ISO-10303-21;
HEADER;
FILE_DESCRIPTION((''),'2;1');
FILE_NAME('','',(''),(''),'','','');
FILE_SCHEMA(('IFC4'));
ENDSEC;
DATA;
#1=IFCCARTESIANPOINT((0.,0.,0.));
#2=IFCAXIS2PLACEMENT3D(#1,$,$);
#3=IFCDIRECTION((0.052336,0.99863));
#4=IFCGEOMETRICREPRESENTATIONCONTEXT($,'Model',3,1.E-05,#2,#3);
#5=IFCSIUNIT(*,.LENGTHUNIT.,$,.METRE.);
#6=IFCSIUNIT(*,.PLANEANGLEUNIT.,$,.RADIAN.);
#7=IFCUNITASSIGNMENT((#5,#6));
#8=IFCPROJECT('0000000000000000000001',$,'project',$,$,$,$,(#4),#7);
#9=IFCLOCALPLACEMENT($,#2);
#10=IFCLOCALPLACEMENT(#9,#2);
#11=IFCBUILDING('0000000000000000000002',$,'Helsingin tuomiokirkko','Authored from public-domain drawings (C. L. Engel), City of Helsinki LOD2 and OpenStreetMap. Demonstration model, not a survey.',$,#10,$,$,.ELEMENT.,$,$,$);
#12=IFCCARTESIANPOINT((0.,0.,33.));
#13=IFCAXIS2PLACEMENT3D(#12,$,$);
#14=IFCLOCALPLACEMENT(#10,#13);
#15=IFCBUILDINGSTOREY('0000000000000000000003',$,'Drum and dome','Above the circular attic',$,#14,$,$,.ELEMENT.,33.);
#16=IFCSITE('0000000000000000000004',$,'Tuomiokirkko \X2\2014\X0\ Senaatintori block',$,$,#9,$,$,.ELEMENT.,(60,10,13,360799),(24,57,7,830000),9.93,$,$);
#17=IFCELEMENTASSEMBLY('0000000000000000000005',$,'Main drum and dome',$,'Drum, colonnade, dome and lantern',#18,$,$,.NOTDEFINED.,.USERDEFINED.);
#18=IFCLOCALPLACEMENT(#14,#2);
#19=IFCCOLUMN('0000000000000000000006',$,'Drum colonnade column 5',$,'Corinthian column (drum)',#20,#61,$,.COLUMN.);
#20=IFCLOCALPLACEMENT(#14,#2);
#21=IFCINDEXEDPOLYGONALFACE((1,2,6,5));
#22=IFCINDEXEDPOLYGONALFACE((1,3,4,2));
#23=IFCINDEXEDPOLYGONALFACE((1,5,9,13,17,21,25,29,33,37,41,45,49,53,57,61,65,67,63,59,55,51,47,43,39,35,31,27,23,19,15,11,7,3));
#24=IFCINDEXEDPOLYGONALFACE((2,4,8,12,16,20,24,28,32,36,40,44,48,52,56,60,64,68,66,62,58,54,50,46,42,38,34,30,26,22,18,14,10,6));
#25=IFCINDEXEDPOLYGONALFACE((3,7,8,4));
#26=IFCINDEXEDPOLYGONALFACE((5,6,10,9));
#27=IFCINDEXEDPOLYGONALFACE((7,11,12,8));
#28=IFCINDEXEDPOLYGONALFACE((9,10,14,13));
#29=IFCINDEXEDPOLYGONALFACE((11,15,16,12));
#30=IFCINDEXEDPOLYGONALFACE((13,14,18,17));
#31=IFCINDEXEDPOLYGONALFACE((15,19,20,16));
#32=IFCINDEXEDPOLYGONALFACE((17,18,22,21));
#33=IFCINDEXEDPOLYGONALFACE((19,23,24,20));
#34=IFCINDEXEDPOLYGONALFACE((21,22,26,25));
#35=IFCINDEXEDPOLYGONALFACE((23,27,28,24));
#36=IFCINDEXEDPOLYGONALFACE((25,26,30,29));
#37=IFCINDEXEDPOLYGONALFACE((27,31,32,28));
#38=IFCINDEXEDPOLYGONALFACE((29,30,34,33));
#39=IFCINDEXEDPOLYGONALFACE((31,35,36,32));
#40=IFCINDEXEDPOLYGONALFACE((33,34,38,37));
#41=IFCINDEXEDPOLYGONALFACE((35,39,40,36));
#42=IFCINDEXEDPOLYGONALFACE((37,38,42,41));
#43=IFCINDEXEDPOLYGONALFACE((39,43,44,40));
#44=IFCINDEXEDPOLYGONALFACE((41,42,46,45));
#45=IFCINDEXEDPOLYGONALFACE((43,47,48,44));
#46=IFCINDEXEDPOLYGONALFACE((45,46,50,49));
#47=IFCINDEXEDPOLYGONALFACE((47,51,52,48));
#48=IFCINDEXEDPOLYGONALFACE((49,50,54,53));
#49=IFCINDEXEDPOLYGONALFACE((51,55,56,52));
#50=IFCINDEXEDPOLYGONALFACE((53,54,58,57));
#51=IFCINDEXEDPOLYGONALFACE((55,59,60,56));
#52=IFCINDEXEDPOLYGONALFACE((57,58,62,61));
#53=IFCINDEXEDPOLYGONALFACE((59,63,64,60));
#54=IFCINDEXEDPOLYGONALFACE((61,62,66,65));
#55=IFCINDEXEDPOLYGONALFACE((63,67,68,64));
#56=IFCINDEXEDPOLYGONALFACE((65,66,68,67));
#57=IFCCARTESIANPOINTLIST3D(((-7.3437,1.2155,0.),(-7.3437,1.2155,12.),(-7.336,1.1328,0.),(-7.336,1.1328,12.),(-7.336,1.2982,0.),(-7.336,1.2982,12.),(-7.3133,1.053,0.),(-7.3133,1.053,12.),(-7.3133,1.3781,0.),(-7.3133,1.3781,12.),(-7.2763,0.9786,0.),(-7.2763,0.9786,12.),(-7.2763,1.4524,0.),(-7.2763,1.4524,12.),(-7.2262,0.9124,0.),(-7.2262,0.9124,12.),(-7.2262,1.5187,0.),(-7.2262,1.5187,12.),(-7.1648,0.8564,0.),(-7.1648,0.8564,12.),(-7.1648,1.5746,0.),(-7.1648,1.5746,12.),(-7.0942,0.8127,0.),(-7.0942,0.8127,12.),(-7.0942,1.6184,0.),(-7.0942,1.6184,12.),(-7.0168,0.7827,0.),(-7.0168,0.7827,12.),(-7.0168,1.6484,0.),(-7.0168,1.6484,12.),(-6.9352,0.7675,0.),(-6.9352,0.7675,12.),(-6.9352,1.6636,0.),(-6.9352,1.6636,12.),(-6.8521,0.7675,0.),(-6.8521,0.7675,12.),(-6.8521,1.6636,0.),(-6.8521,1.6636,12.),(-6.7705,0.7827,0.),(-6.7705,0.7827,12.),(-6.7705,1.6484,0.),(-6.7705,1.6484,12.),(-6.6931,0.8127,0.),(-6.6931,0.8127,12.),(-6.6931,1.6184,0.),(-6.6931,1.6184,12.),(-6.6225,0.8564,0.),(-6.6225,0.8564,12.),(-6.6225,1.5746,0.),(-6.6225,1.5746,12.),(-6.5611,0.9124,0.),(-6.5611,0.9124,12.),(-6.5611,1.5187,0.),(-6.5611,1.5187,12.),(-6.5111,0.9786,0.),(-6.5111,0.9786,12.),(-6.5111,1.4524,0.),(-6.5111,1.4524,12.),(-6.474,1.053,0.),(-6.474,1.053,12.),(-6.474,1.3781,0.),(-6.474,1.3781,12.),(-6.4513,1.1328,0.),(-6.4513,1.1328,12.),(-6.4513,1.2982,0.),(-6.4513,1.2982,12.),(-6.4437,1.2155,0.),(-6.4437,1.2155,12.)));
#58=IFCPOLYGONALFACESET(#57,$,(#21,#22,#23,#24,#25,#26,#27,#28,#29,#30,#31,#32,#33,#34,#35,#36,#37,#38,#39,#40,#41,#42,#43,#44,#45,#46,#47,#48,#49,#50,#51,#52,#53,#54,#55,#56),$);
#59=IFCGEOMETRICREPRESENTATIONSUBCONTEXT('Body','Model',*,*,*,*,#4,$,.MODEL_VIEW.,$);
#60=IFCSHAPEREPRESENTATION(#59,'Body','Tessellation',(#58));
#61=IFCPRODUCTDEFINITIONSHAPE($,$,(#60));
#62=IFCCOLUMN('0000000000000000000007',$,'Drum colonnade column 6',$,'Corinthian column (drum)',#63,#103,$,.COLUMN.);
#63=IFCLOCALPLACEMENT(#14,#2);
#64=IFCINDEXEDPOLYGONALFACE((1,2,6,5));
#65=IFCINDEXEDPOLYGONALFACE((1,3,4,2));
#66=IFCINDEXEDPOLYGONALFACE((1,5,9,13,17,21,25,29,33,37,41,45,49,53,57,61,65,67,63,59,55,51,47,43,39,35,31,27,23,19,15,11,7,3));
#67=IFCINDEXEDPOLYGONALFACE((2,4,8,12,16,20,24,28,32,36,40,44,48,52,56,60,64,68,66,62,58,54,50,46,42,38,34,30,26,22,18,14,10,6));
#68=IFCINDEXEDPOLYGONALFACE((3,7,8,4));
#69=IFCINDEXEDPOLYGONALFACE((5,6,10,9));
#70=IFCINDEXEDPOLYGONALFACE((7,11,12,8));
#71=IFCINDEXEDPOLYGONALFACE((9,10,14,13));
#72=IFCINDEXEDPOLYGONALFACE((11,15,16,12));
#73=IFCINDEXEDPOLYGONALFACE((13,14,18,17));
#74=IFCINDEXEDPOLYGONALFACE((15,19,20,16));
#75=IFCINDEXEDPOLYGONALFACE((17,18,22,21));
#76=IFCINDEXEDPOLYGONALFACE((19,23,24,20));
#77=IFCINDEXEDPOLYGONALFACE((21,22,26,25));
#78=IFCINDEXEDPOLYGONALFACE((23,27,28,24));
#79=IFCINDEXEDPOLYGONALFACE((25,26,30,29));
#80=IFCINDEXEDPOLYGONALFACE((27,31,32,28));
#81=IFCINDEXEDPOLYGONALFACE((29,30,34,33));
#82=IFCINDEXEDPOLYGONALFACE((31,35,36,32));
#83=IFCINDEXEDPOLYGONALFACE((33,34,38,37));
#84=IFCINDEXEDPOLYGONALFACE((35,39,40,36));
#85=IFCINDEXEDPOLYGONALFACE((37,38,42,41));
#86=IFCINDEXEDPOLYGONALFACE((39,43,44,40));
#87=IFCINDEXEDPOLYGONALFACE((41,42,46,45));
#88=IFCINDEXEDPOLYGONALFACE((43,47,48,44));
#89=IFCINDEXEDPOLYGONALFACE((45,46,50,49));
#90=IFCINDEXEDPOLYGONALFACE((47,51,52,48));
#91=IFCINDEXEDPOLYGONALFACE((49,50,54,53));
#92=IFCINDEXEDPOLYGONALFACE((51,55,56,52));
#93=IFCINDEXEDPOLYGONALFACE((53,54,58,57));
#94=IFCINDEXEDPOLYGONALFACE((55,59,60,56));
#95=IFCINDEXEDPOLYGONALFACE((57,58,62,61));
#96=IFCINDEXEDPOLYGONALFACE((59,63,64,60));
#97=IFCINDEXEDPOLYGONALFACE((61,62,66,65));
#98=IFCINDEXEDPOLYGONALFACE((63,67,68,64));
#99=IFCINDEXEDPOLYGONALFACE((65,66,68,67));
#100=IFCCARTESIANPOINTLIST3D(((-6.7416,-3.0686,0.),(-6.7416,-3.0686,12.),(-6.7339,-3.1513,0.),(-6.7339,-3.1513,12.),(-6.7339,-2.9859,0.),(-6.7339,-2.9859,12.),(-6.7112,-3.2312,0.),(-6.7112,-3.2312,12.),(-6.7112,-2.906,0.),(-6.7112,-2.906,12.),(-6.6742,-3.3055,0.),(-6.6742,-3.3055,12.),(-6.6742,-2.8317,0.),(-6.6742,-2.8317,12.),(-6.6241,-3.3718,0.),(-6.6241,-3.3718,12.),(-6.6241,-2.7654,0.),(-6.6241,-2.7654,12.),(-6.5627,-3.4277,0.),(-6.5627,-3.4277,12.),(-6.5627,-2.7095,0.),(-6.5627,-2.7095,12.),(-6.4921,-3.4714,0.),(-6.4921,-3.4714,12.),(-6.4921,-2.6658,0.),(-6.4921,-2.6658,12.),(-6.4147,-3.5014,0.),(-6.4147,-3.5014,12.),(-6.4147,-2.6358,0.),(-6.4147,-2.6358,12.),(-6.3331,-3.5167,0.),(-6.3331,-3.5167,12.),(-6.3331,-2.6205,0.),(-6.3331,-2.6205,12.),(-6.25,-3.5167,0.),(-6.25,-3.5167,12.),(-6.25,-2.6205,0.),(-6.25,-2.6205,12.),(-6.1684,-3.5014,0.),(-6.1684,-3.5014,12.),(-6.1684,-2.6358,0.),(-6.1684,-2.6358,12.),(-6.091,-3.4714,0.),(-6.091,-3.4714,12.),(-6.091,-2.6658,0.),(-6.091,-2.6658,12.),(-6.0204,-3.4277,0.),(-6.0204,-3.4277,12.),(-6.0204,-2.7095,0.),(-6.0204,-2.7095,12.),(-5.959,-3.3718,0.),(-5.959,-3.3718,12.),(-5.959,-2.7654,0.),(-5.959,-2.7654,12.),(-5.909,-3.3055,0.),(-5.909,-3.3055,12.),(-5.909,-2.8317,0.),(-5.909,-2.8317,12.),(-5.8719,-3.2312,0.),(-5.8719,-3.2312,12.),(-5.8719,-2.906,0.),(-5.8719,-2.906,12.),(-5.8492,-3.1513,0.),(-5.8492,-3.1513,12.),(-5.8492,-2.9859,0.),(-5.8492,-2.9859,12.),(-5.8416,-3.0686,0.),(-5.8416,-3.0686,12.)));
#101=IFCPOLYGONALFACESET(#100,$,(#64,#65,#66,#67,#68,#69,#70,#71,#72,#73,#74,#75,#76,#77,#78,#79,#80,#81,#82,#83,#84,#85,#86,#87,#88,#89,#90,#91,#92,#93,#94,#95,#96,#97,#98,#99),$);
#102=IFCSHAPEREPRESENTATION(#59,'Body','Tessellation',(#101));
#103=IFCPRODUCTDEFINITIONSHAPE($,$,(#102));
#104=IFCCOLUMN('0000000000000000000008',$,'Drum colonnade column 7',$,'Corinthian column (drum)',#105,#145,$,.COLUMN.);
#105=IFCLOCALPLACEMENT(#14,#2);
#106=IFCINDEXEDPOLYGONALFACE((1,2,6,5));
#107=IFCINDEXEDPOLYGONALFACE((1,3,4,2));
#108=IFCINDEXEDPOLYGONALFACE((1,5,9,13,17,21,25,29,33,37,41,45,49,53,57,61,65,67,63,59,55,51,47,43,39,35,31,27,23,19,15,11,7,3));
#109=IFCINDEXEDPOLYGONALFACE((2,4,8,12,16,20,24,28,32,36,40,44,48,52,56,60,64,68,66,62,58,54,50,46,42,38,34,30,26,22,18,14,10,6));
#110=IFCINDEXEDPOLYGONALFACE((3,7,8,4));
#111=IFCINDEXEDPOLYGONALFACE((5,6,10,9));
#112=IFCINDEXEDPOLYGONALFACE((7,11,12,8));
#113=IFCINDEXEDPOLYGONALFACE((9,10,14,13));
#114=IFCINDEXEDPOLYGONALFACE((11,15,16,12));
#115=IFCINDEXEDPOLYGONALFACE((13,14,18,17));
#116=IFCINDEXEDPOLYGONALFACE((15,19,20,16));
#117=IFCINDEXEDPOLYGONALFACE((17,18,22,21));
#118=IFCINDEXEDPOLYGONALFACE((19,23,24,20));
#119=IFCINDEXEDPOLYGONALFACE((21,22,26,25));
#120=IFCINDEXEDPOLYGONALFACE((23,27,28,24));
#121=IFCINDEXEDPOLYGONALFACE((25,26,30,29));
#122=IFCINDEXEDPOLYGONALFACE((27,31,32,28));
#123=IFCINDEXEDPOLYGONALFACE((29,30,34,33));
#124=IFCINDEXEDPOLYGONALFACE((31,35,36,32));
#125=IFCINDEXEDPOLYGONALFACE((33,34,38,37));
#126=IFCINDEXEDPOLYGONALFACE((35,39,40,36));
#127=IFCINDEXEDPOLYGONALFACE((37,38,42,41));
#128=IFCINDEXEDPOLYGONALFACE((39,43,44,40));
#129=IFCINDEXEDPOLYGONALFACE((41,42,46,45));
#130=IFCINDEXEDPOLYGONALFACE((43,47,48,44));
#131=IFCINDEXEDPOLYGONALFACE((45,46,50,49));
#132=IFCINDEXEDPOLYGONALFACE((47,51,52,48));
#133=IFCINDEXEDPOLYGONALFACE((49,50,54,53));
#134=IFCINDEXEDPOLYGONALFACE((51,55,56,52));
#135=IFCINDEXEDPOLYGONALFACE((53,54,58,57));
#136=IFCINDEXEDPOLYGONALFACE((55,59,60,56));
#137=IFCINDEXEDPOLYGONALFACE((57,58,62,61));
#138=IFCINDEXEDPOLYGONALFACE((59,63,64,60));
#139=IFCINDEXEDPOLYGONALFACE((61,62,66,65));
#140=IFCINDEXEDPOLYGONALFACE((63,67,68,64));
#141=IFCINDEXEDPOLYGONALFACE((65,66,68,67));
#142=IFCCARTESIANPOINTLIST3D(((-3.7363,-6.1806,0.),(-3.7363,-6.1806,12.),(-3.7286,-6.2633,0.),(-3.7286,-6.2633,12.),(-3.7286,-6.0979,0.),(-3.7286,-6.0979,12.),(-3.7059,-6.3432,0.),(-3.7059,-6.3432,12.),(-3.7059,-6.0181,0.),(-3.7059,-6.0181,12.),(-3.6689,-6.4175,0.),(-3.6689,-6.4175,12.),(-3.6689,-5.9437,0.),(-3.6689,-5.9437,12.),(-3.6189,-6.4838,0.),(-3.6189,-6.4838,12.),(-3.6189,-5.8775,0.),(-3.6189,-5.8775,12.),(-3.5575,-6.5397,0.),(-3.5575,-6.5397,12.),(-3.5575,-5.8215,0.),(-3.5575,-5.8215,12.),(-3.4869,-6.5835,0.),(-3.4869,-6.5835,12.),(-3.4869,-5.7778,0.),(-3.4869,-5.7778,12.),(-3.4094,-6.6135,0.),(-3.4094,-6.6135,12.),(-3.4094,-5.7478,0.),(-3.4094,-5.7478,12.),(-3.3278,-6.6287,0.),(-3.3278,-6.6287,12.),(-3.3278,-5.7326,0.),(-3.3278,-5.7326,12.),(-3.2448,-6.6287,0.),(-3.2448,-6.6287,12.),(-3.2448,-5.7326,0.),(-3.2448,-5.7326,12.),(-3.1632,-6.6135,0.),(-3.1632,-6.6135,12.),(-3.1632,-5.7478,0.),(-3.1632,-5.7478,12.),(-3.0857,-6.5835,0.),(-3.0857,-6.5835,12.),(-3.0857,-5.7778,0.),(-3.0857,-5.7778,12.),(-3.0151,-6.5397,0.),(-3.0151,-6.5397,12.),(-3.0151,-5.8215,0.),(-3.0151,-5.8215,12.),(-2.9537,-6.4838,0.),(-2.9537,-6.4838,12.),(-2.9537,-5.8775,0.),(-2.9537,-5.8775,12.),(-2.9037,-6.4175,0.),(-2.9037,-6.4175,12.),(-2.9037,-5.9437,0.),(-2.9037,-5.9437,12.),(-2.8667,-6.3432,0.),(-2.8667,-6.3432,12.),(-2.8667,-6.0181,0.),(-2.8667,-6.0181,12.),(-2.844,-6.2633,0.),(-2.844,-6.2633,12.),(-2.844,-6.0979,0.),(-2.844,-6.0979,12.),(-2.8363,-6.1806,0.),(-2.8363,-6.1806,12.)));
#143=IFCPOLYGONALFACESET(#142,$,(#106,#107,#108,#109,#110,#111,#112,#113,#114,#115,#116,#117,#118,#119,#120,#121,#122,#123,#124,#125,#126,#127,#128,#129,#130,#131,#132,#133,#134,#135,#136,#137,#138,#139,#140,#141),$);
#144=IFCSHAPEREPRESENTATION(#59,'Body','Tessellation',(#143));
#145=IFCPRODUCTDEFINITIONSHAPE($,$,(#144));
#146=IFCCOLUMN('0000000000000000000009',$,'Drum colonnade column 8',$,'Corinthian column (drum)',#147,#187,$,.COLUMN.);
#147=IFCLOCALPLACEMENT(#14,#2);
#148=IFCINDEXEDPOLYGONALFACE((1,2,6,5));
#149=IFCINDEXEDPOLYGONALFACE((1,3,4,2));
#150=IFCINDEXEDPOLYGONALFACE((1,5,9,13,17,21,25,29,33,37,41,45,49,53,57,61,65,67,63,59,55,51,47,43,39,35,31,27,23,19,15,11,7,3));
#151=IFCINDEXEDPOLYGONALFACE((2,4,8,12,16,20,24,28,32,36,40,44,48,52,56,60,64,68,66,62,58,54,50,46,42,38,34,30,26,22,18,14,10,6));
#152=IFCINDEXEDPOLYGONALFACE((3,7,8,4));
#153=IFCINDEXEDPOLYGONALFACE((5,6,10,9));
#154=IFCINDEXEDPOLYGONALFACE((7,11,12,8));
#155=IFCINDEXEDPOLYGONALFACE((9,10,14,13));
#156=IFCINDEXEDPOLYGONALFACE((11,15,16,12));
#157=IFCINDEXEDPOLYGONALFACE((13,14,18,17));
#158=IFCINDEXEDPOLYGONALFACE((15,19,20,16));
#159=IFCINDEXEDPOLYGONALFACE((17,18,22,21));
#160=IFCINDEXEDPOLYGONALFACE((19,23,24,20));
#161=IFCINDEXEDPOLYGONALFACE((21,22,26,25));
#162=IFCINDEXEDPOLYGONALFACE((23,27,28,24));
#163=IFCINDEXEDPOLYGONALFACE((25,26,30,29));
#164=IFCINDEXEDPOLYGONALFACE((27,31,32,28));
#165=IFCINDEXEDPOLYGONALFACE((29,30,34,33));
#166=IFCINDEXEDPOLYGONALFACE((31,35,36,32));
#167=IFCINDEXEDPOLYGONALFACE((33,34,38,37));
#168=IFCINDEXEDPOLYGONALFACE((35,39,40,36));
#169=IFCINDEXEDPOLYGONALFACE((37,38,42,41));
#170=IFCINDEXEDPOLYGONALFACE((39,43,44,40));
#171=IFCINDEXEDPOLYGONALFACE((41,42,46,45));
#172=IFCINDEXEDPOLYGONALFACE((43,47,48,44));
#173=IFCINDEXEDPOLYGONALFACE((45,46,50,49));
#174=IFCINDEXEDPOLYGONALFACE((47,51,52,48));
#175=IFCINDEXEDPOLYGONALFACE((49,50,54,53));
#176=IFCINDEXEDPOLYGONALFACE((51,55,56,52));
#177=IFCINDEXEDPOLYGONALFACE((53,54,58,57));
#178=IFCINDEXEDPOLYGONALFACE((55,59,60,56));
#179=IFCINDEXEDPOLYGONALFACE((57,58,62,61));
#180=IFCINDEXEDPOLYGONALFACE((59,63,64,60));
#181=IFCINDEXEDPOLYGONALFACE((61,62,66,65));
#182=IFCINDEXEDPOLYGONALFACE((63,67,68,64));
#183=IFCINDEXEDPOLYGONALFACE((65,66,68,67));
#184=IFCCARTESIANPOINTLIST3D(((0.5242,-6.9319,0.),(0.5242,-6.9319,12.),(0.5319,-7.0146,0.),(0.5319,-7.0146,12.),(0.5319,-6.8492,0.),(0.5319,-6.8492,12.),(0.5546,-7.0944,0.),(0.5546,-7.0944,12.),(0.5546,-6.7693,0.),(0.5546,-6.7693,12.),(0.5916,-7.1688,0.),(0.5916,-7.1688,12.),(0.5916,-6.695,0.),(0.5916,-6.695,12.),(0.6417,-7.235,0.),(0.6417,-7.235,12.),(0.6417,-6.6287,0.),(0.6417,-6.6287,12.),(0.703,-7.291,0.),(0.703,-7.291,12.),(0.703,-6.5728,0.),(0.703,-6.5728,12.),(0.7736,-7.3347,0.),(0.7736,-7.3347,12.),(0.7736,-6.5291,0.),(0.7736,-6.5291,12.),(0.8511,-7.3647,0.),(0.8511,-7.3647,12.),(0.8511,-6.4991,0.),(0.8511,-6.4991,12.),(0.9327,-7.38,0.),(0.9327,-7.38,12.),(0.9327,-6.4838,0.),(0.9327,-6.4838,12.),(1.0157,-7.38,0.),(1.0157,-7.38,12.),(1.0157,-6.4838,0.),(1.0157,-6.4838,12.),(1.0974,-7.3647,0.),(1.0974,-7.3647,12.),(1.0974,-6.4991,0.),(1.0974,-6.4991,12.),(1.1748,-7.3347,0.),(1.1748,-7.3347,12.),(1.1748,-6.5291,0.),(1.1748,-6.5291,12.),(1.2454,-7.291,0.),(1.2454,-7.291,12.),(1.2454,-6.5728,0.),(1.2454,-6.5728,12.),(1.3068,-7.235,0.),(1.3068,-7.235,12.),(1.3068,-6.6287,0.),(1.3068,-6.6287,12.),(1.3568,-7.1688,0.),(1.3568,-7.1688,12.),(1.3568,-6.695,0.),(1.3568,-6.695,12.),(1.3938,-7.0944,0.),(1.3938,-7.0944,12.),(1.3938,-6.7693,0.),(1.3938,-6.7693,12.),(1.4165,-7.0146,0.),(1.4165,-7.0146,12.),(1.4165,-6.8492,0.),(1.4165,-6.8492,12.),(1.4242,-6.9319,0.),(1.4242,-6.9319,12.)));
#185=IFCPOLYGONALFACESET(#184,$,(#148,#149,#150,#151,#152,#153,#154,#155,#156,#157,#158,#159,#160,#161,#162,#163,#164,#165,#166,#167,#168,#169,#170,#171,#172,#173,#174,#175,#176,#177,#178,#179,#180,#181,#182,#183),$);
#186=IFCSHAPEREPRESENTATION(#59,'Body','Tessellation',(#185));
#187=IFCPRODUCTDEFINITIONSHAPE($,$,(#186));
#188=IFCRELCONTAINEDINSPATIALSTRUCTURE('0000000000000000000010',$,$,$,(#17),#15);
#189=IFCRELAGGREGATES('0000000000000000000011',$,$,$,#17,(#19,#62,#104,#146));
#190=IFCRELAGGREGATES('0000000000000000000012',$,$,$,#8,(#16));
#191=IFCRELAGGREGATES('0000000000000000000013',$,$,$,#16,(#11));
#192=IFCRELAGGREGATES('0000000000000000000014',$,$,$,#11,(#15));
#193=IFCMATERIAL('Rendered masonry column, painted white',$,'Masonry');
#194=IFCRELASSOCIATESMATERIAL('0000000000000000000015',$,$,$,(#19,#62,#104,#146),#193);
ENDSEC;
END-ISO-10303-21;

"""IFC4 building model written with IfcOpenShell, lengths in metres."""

from ifc_helpers import new_model, si_unit, direction, frame, origin, origin_2d_with_axis, place, context, subcontext, project, spatial, circle, extrude, material, element, aggregate, save


model = new_model("IFC4")

# Units and contexts
model_context = context("Model", 3, precision=1e-05, world=origin(), true_north=direction((0.052336, 0.99863)))
body_context = subcontext(model_context, "Body", "Model", "MODEL_VIEW")
ifc_project = project(units=[si_unit("LENGTHUNIT", "METRE"), si_unit("PLANEANGLEUNIT", "RADIAN")], contexts=[model_context])

# Site, building, storey
site_placement = place(None, origin())
site = spatial("IfcSite", under=ifc_project, at=site_placement, Name="Tuomiokirkko — Senaatintori block", CompositionType="ELEMENT", RefLatitude=(60, 10, 13, 360799), RefLongitude=(24, 57, 7, 830000), RefElevation=9.93)
building_placement = place(site_placement, origin())
building = spatial("IfcBuilding", under=site, at=building_placement, Name="Helsingin tuomiokirkko", Description="Authored from public-domain drawings (C. L. Engel), City of Helsinki LOD2 and OpenStreetMap. Demonstration model, not a survey.", CompositionType="ELEMENT")
storey_placement = place(building_placement, frame((0.0, 0.0, 33.0)))
storey = spatial("IfcBuildingStorey", under=building, at=storey_placement, Name="Drum and dome", Description="Above the circular attic", CompositionType="ELEMENT", Elevation=33.0)

# Element assembly, columns
assembly_placement = place(building_placement, origin())
assembly = element("IfcElementAssembly", 1, at=assembly_placement, inside=storey, Name="Main drum and dome", ObjectType="Drum, colonnade, dome and lantern", AssemblyPlace="NOTDEFINED", PredefinedType="USERDEFINED")
ifc_material_1 = material(Name="Rendered masonry column, painted white", Category="Masonry")
column_1_placement = place(building_placement, origin())
column_1 = element("IfcColumn", 2, at=column_1_placement, material=ifc_material_1, Name="Drum colonnade column 5", ObjectType="Corinthian column (drum)", PredefinedType="COLUMN", context=body_context, shape_type="SweptSolid", body=[
    extrude(circle(Radius=0.45, at=origin_2d_with_axis()), frame((-6.8937, 1.2155, 33.0)), (0.0, 0.0, 1.0), 12.0),
])
column_2_placement = place(building_placement, origin())
column_2 = element("IfcColumn", 3, at=column_2_placement, material=ifc_material_1, Name="Drum colonnade column 6", ObjectType="Corinthian column (drum)", PredefinedType="COLUMN", context=body_context, shape_type="SweptSolid", body=[
    extrude(circle(Radius=0.45, at=origin_2d_with_axis()), frame((-6.2916, -3.0686, 33.0)), (0.0, 0.0, 1.0), 12.0),
])
column_3_placement = place(building_placement, origin())
column_3 = element("IfcColumn", 4, at=column_3_placement, material=ifc_material_1, Name="Drum colonnade column 7", ObjectType="Corinthian column (drum)", PredefinedType="COLUMN", context=body_context, shape_type="SweptSolid", body=[
    extrude(circle(Radius=0.45, at=origin_2d_with_axis()), frame((-3.2863, -6.1806, 33.0)), (0.0, 0.0, 1.0), 12.0),
])
column_4_placement = place(building_placement, origin())
column_4 = element("IfcColumn", 5, at=column_4_placement, material=ifc_material_1, Name="Drum colonnade column 8", ObjectType="Corinthian column (drum)", PredefinedType="COLUMN", context=body_context, shape_type="SweptSolid", body=[
    extrude(circle(Radius=0.45, at=origin_2d_with_axis()), frame((0.9742, -6.9319, 33.0)), (0.0, 0.0, 1.0), 12.0),
])
aggregate(assembly, [column_1, column_2, column_3, column_4])

save(model, "model.ifc")
